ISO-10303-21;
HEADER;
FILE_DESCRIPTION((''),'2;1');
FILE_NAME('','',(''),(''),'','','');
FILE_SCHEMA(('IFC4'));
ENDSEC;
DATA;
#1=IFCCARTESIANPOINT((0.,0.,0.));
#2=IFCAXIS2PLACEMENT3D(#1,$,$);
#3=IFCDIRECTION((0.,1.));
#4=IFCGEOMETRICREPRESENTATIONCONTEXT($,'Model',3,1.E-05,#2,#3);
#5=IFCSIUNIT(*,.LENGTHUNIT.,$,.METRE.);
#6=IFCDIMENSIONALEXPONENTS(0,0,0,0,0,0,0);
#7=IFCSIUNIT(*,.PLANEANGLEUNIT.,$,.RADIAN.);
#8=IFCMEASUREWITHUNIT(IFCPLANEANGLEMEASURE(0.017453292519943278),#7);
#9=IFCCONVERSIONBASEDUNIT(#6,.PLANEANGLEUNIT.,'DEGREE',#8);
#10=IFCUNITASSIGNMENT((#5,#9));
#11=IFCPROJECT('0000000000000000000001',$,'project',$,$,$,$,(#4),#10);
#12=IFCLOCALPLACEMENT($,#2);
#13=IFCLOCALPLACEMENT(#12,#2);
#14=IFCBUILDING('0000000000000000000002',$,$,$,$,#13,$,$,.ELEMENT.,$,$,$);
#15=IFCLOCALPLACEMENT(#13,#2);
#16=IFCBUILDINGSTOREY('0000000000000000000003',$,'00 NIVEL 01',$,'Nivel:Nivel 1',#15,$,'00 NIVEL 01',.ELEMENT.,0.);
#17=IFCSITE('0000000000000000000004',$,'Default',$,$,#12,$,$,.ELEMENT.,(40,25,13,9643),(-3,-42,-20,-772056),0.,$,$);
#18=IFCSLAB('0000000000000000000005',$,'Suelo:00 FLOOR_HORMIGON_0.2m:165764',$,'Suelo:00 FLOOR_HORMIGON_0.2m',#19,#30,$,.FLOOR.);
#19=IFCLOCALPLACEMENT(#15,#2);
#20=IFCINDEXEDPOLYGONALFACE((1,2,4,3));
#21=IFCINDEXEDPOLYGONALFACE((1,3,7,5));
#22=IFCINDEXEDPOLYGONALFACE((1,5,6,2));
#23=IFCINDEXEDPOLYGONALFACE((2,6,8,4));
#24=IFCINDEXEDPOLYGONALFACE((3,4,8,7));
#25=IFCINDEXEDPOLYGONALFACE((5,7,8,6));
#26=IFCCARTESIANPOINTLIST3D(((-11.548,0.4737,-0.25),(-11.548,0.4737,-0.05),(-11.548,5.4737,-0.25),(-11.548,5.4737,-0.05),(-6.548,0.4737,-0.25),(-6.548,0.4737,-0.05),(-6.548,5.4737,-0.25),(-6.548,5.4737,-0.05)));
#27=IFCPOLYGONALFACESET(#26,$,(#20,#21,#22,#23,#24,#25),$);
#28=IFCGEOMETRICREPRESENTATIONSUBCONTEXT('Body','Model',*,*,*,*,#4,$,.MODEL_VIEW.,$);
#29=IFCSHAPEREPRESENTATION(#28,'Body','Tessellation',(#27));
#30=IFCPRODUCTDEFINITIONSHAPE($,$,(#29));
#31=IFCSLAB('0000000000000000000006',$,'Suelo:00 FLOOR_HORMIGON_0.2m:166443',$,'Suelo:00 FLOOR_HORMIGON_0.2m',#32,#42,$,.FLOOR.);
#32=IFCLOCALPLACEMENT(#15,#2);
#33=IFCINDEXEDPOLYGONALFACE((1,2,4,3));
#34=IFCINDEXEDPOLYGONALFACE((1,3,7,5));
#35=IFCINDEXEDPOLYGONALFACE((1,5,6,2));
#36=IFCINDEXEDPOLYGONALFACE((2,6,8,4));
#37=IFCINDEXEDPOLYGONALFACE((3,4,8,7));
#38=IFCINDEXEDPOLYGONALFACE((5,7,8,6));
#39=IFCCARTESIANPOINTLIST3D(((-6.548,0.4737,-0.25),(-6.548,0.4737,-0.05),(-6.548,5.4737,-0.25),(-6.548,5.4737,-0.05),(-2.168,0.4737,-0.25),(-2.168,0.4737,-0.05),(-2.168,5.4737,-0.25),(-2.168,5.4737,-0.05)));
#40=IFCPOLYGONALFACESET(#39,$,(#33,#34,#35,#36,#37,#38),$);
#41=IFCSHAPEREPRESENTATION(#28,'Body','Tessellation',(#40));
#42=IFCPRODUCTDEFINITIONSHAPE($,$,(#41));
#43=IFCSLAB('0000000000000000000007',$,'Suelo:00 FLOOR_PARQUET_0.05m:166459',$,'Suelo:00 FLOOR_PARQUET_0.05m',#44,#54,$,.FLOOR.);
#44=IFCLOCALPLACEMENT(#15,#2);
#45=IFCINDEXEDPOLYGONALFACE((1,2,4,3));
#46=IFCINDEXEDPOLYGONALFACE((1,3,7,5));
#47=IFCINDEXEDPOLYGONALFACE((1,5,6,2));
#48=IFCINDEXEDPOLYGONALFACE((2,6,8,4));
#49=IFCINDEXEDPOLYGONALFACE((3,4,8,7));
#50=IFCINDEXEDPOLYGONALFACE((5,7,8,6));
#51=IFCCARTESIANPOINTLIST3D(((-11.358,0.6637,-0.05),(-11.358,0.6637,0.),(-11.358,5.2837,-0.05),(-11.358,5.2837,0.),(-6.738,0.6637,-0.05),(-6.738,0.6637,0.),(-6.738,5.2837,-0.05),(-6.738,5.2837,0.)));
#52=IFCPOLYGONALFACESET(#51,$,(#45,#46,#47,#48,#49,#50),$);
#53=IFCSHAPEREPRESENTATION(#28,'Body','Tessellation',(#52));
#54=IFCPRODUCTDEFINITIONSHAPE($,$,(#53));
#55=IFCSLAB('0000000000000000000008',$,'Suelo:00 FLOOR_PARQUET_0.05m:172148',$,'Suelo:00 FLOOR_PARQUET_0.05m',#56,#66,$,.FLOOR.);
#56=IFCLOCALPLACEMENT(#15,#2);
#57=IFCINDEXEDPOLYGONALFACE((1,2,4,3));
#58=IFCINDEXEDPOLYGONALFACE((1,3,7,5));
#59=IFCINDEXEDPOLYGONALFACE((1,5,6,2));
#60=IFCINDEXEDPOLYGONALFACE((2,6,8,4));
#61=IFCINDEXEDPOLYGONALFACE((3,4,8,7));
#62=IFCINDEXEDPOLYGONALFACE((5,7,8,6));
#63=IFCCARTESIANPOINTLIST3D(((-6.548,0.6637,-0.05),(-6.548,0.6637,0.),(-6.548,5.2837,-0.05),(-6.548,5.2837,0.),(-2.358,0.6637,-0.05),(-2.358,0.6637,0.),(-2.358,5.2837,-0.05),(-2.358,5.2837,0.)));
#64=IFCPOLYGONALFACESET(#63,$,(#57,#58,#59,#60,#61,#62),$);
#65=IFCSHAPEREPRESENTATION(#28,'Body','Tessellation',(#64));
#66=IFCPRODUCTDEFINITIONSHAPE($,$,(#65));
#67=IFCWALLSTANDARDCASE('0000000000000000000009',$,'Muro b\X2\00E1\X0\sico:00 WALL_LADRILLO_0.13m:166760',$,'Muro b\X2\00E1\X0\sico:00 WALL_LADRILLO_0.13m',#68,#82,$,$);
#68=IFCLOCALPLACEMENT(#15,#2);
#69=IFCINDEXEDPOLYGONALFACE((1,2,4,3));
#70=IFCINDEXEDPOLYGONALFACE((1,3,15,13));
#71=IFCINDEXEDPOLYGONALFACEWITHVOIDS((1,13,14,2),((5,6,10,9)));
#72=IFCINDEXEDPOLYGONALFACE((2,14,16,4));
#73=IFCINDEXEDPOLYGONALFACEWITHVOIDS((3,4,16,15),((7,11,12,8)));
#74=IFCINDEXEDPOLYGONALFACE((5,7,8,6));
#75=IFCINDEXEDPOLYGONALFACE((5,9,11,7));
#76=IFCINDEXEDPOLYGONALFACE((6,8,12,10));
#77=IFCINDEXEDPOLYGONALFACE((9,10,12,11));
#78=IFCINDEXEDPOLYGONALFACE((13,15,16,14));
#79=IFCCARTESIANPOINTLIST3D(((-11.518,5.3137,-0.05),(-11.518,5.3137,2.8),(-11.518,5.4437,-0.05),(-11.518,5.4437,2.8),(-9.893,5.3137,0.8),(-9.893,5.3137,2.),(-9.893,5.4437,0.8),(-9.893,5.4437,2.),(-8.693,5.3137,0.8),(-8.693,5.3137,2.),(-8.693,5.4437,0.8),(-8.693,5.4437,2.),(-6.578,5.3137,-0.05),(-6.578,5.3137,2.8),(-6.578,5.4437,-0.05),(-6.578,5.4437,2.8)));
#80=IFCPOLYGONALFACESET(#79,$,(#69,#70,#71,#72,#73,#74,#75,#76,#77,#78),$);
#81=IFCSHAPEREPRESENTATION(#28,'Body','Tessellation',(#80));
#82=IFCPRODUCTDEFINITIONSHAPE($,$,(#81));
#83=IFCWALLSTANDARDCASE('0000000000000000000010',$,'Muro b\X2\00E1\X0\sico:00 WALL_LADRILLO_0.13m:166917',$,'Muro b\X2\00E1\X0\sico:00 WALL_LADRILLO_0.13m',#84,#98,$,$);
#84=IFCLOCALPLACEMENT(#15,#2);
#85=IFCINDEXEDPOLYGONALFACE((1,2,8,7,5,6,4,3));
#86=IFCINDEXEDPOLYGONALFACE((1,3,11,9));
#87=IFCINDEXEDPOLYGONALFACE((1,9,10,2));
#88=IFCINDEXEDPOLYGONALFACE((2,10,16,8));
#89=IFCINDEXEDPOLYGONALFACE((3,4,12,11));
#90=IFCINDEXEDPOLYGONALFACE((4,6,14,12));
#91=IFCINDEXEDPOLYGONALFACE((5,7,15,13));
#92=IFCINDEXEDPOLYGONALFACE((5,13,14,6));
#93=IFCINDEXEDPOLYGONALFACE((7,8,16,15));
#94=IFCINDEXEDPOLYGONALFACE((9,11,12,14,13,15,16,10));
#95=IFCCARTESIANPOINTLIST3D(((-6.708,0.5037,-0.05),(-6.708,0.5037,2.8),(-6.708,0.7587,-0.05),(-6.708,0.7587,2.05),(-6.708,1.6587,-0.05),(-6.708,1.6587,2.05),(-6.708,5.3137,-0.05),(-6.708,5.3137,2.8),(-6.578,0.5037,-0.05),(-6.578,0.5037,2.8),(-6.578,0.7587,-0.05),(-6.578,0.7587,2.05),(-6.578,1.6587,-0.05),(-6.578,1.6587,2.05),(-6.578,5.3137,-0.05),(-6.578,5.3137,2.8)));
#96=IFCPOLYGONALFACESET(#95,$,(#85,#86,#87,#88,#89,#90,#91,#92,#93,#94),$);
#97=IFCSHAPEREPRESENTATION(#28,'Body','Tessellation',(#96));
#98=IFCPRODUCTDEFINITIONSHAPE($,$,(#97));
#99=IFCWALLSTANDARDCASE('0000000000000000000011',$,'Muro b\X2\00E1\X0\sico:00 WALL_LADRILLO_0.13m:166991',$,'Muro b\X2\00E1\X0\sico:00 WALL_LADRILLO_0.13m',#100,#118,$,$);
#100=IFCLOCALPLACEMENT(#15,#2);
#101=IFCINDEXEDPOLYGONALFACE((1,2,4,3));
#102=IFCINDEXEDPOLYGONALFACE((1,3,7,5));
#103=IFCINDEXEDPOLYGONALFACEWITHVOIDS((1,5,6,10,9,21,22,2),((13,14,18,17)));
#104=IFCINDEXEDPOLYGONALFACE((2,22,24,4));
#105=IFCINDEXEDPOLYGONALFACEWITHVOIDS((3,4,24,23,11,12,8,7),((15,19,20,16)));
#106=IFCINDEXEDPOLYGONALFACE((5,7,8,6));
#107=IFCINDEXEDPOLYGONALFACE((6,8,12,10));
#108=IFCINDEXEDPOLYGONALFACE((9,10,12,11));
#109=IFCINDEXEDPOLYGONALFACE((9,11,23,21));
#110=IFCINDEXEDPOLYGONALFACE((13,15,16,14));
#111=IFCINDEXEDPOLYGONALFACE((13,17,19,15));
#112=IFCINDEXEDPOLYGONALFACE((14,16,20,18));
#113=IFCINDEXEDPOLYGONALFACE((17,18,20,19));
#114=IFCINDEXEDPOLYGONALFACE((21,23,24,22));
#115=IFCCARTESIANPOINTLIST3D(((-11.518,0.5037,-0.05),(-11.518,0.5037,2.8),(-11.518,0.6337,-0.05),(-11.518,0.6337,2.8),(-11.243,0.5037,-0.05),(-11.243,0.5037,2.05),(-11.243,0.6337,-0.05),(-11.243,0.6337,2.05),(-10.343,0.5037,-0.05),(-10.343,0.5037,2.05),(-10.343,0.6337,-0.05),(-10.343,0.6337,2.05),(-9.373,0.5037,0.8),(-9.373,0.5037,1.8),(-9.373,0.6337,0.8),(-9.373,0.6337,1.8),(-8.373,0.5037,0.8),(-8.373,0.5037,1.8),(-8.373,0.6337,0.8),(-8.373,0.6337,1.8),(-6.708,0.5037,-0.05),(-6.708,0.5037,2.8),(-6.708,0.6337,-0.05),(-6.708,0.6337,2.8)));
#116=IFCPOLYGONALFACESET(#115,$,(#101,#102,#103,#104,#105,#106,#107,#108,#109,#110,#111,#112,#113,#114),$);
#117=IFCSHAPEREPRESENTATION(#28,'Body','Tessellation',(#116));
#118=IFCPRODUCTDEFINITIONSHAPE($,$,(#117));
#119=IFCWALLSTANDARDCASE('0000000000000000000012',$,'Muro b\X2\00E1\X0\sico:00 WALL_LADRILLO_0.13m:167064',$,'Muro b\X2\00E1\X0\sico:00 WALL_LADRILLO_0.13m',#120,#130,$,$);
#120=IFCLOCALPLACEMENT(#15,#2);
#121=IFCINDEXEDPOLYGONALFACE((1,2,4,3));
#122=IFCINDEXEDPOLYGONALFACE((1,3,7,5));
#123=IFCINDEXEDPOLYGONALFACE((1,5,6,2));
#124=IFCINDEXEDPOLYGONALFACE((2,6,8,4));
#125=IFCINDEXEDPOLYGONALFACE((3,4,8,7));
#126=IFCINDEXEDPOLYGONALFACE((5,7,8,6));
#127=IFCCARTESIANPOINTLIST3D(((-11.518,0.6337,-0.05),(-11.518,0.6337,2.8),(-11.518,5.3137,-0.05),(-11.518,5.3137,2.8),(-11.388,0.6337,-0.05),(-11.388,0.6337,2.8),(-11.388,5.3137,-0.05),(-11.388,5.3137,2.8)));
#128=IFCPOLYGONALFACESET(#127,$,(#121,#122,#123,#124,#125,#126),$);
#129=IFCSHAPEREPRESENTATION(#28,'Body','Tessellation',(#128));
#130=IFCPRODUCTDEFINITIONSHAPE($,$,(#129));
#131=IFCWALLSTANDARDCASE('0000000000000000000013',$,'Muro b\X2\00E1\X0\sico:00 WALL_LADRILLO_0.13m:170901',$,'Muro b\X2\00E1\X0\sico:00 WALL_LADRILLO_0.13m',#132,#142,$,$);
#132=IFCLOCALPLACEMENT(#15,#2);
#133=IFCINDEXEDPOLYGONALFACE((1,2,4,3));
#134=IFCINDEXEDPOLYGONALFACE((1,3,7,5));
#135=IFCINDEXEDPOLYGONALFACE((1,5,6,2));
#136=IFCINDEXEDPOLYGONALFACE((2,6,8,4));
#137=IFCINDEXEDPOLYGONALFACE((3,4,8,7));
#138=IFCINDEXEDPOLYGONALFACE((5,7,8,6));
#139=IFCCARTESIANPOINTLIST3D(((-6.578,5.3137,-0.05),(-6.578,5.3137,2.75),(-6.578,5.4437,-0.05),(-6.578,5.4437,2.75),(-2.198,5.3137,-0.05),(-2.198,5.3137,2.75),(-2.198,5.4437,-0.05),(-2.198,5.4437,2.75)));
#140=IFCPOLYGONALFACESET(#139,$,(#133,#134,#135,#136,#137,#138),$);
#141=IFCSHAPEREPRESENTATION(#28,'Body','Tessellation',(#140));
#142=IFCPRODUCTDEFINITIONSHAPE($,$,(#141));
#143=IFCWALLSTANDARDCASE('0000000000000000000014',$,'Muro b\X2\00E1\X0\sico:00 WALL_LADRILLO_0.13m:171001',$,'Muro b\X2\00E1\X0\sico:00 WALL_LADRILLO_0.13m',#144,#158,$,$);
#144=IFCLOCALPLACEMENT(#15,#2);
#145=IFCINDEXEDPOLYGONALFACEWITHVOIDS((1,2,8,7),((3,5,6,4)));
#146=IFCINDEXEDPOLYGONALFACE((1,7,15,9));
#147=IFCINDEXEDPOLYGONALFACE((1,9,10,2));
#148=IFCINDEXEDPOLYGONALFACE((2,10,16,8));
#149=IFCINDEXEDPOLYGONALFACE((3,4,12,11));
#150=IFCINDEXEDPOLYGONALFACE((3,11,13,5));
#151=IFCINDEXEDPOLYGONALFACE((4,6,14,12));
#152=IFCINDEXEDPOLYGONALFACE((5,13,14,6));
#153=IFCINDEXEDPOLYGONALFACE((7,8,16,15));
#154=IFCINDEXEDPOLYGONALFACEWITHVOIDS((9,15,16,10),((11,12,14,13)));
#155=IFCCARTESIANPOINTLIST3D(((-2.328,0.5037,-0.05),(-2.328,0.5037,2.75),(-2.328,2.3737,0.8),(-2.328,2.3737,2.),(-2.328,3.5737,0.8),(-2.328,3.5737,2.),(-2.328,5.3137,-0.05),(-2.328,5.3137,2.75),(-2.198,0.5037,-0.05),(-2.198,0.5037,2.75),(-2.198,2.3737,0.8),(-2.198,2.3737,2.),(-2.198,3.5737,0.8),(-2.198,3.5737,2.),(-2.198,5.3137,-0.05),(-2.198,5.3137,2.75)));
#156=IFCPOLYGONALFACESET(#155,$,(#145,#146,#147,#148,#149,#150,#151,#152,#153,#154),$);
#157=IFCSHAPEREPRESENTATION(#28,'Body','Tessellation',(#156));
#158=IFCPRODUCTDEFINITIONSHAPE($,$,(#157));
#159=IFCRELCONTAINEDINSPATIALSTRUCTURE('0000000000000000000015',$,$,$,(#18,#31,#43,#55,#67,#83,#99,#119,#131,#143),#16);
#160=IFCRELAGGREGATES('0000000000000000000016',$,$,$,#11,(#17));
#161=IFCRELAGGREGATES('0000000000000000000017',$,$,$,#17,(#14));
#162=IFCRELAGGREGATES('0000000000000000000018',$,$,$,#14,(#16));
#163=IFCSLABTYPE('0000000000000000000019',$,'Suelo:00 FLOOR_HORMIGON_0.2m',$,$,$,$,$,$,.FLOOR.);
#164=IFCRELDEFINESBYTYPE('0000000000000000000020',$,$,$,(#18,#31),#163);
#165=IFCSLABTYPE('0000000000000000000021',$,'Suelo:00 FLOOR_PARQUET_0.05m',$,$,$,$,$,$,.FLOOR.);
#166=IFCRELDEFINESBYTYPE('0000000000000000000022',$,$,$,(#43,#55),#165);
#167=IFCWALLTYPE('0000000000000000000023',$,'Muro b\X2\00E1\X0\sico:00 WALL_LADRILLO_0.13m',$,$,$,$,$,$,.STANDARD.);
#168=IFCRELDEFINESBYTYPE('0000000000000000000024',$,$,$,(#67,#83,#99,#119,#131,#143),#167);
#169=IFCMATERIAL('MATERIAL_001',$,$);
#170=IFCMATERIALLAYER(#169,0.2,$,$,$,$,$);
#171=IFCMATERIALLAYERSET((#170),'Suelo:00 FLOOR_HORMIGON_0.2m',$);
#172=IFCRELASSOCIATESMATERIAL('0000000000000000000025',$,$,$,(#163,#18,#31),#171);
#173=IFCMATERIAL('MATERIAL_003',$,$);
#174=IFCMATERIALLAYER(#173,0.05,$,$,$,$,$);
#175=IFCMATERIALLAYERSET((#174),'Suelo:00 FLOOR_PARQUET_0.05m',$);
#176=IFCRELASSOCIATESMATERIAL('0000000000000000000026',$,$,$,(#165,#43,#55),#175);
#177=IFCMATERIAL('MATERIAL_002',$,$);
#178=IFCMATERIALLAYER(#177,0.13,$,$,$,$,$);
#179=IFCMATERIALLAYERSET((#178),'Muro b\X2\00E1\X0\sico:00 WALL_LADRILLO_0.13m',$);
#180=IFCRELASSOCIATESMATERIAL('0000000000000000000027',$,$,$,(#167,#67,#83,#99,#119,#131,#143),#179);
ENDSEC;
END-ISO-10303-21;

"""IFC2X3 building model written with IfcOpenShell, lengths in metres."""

from ifc_helpers import new_model, entity, si_unit, converted_unit, direction, frame, frame_2d, origin, place, context, subcontext, project, spatial, rectangle, extrude, material, layer, layer_set, layer_usage, type_object, element, save


model = new_model("IFC2X3")

# Units and contexts
model_context = context("Model", 3, precision=1e-05, world=origin(), true_north=direction((0.0, 1.0)))
body_context = subcontext(model_context, "Body", "Model", "MODEL_VIEW")
ifc_project = project(units=[si_unit("LENGTHUNIT", "METRE"), converted_unit("PLANEANGLEUNIT", "DEGREE", entity("IfcPlaneAngleMeasure", 0.017453292519943278), si_unit("PLANEANGLEUNIT", "RADIAN"), dimensions=[0, 0, 0, 0, 0, 0, 0])], contexts=[model_context])

# Site, building, storey
site_placement = place(None, origin())
site = spatial("IfcSite", under=ifc_project, at=site_placement, Name="Default", CompositionType="ELEMENT", RefLatitude=(40, 25, 13, 9643), RefLongitude=(-3, -42, -20, -772056), RefElevation=0.0)
building_placement = place(site_placement, origin())
building = spatial("IfcBuilding", under=site, at=building_placement, CompositionType="ELEMENT")
storey_placement = place(building_placement, origin())
storey = spatial("IfcBuildingStorey", under=building, at=storey_placement, Name="00 NIVEL 01", ObjectType="Nivel:Nivel 1", LongName="00 NIVEL 01", CompositionType="ELEMENT", Elevation=0.0)

# Slabs
ifc_material_1 = material(Name="MATERIAL_001")
ifc_layer_1 = layer(ifc_material_1, 0.2)
ifc_layer_set_1 = layer_set([ifc_layer_1], Name="Suelo:00 FLOOR_HORMIGON_0.2m")
ifc_layer_usage_1 = layer_usage(ifc_layer_set_1, "AXIS3", "POSITIVE", 0.0)
slab_type_1 = type_object("IfcSlabType", Name="Suelo:00 FLOOR_HORMIGON_0.2m", PredefinedType="FLOOR", material=ifc_layer_set_1)
slab_1_placement = place(storey_placement, origin())
element("IfcSlab", 1, at=slab_1_placement, inside=storey, type_object=slab_type_1, material=ifc_layer_usage_1, Name="Suelo:00 FLOOR_HORMIGON_0.2m:165764", ObjectType="Suelo:00 FLOOR_HORMIGON_0.2m", PredefinedType="FLOOR", context=body_context, shape_type="SweptSolid", body=[
    extrude(rectangle(XDim=5.0, YDim=5.0, at=frame_2d((0.0, 0.0), x_axis=(1.0, 0.0))), frame((-9.048, 2.9737, -0.05), z_axis=(0.0, 0.0, -1.0), x_axis=(0.0, 1.0, 0.0)), (0.0, 0.0, 1.0), 0.2),
])
ifc_layer_usage_2 = layer_usage(ifc_layer_set_1, "AXIS3", "POSITIVE", 0.0)
slab_2_placement = place(storey_placement, origin())
element("IfcSlab", 2, at=slab_2_placement, inside=storey, type_object=slab_type_1, material=ifc_layer_usage_2, Name="Suelo:00 FLOOR_HORMIGON_0.2m:166443", ObjectType="Suelo:00 FLOOR_HORMIGON_0.2m", PredefinedType="FLOOR", context=body_context, shape_type="SweptSolid", body=[
    extrude(rectangle(XDim=5.0, YDim=4.38, at=frame_2d((0.0, 0.0), x_axis=(1.0, 0.0))), frame((-4.358, 2.9737, -0.05), z_axis=(0.0, 0.0, -1.0), x_axis=(0.0, 1.0, 0.0)), (0.0, 0.0, 1.0), 0.2),
])
ifc_material_2 = material(Name="MATERIAL_003")
ifc_layer_2 = layer(ifc_material_2, 0.05)
ifc_layer_set_2 = layer_set([ifc_layer_2], Name="Suelo:00 FLOOR_PARQUET_0.05m")
ifc_layer_usage_3 = layer_usage(ifc_layer_set_2, "AXIS3", "POSITIVE", 0.0)
slab_type_2 = type_object("IfcSlabType", Name="Suelo:00 FLOOR_PARQUET_0.05m", PredefinedType="FLOOR", material=ifc_layer_set_2)
slab_3_placement = place(storey_placement, origin())
element("IfcSlab", 3, at=slab_3_placement, inside=storey, type_object=slab_type_2, material=ifc_layer_usage_3, Name="Suelo:00 FLOOR_PARQUET_0.05m:166459", ObjectType="Suelo:00 FLOOR_PARQUET_0.05m", PredefinedType="FLOOR", context=body_context, shape_type="SweptSolid", body=[
    extrude(rectangle(XDim=4.62, YDim=4.62, at=frame_2d((0.0, 0.0), x_axis=(1.0, 0.0))), frame((-9.048, 2.9737, 0.0), z_axis=(0.0, 0.0, -1.0), x_axis=(0.0, 1.0, 0.0)), (0.0, 0.0, 1.0), 0.05),
])
ifc_layer_usage_4 = layer_usage(ifc_layer_set_2, "AXIS3", "POSITIVE", 0.0)
slab_4_placement = place(storey_placement, origin())
element("IfcSlab", 4, at=slab_4_placement, inside=storey, type_object=slab_type_2, material=ifc_layer_usage_4, Name="Suelo:00 FLOOR_PARQUET_0.05m:172148", ObjectType="Suelo:00 FLOOR_PARQUET_0.05m", PredefinedType="FLOOR", context=body_context, shape_type="SweptSolid", body=[
    extrude(rectangle(XDim=4.62, YDim=4.19, at=frame_2d((0.0, 0.0), x_axis=(1.0, 0.0))), frame((-4.453, 2.9737, 0.0), z_axis=(0.0, 0.0, -1.0), x_axis=(0.0, 1.0, 0.0)), (0.0, 0.0, 1.0), 0.05),
])

# Walls, openings
ifc_material_3 = material(Name="MATERIAL_002")
ifc_layer_3 = layer(ifc_material_3, 0.13)
ifc_layer_set_3 = layer_set([ifc_layer_3], Name="Muro básico:00 WALL_LADRILLO_0.13m")
ifc_layer_usage_5 = layer_usage(ifc_layer_set_3, "AXIS2", "NEGATIVE", 0.065)
wall_type_1 = type_object("IfcWallType", Name="Muro básico:00 WALL_LADRILLO_0.13m", PredefinedType="STANDARD", material=ifc_layer_set_3)
wall_1_placement = place(storey_placement, frame((-11.518, 5.3787, -0.05)))
wall_1 = element("IfcWallStandardCase", 5, at=wall_1_placement, inside=storey, type_object=wall_type_1, material=ifc_layer_usage_5, Name="Muro básico:00 WALL_LADRILLO_0.13m:166760", ObjectType="Muro básico:00 WALL_LADRILLO_0.13m", context=body_context, shape_type="SweptSolid", body=[
    extrude(rectangle(XDim=4.94, YDim=0.13, at=frame_2d((2.47, 0.0), x_axis=(-1.0, 0.0))), origin(), (0.0, 0.0, 1.0), 2.85),
])
opening_1_placement = place(wall_1_placement, frame((1.625, -0.065, 0.85)))
element("IfcOpeningElement", 6, at=opening_1_placement, cuts=wall_1, ObjectType="Opening", context=body_context, shape_type="SweptSolid", body=[
    extrude(rectangle(XDim=1.2, YDim=1.2, at=frame_2d((0.6, 0.6), x_axis=(1.0, 0.0))), frame((0.0, 0.0, 0.0), z_axis=(0.0, 1.0, 0.0), x_axis=(0.0, 0.0, 1.0)), (0.0, 0.0, 1.0), 0.13),
])
ifc_layer_usage_6 = layer_usage(ifc_layer_set_3, "AXIS2", "NEGATIVE", 0.065)
wall_2_placement = place(storey_placement, frame((-6.643, 5.3137, -0.05), z_axis=(0.0, 0.0, 1.0), x_axis=(0.0, -1.0, 0.0)))
wall_2 = element("IfcWallStandardCase", 7, at=wall_2_placement, inside=storey, type_object=wall_type_1, material=ifc_layer_usage_6, Name="Muro básico:00 WALL_LADRILLO_0.13m:166917", ObjectType="Muro básico:00 WALL_LADRILLO_0.13m", context=body_context, shape_type="SweptSolid", body=[
    extrude(rectangle(XDim=4.81, YDim=0.13, at=frame_2d((2.405, 0.0), x_axis=(-1.0, 0.0))), origin(), (0.0, 0.0, 1.0), 2.85),
])
opening_2_placement = place(wall_2_placement, frame((3.655, -0.065, 0.0)))
element("IfcOpeningElement", 8, at=opening_2_placement, cuts=wall_2, ObjectType="Opening", context=body_context, shape_type="SweptSolid", body=[
    extrude(rectangle(XDim=2.1, YDim=0.9, at=frame_2d((1.05, 0.45), x_axis=(1.0, 0.0))), frame((0.0, 0.0, 0.0), z_axis=(0.0, 1.0, 0.0), x_axis=(0.0, 0.0, 1.0)), (0.0, 0.0, 1.0), 0.13),
])

# Wall, openings
ifc_layer_usage_7 = layer_usage(ifc_layer_set_3, "AXIS2", "NEGATIVE", 0.065)
wall_3_placement = place(storey_placement, frame((-6.708, 0.5687, -0.05), z_axis=(0.0, 0.0, 1.0), x_axis=(-1.0, 0.0, 0.0)))
wall_3 = element("IfcWallStandardCase", 9, at=wall_3_placement, inside=storey, type_object=wall_type_1, material=ifc_layer_usage_7, Name="Muro básico:00 WALL_LADRILLO_0.13m:166991", ObjectType="Muro básico:00 WALL_LADRILLO_0.13m", context=body_context, shape_type="SweptSolid", body=[
    extrude(rectangle(XDim=4.81, YDim=0.13, at=frame_2d((2.405, 0.0), x_axis=(1.0, 0.0))), origin(), (0.0, 0.0, 1.0), 2.85),
])
opening_3_placement = place(wall_3_placement, frame((4.535, 0.065, 0.0)))
element("IfcOpeningElement", 10, at=opening_3_placement, cuts=wall_3, ObjectType="Opening", context=body_context, shape_type="SweptSolid", body=[
    extrude(rectangle(XDim=2.1, YDim=0.9, at=frame_2d((1.05, 0.45), x_axis=(1.0, 0.0))), frame((0.0, 0.0, 0.0), z_axis=(0.0, -1.0, 0.0), x_axis=(0.0, 0.0, 1.0)), (0.0, 0.0, 1.0), 0.13),
])
opening_4_placement = place(wall_3_placement, frame((2.665, 0.065, 0.85)))
element("IfcOpeningElement", 11, at=opening_4_placement, cuts=wall_3, ObjectType="Opening", context=body_context, shape_type="SweptSolid", body=[
    extrude(rectangle(XDim=1.0, YDim=1.0, at=frame_2d((0.5, 0.5), x_axis=(1.0, 0.0))), frame((0.0, 0.0, 0.0), z_axis=(0.0, -1.0, 0.0), x_axis=(0.0, 0.0, 1.0)), (0.0, 0.0, 1.0), 0.13),
])

# Walls
ifc_layer_usage_8 = layer_usage(ifc_layer_set_3, "AXIS2", "NEGATIVE", 0.065)
wall_4_placement = place(storey_placement, frame((-11.453, 0.6337, -0.05), z_axis=(0.0, 0.0, 1.0), x_axis=(0.0, 1.0, 0.0)))
element("IfcWallStandardCase", 12, at=wall_4_placement, inside=storey, type_object=wall_type_1, material=ifc_layer_usage_8, Name="Muro básico:00 WALL_LADRILLO_0.13m:167064", ObjectType="Muro básico:00 WALL_LADRILLO_0.13m", context=body_context, shape_type="SweptSolid", body=[
    extrude(rectangle(XDim=4.68, YDim=0.13, at=frame_2d((2.34, 0.0), x_axis=(-1.0, 0.0))), origin(), (0.0, 0.0, 1.0), 2.85),
])
ifc_layer_usage_9 = layer_usage(ifc_layer_set_3, "AXIS2", "NEGATIVE", 0.065)
wall_5_placement = place(storey_placement, frame((-6.578, 5.3787, -0.05)))
element("IfcWallStandardCase", 13, at=wall_5_placement, inside=storey, type_object=wall_type_1, material=ifc_layer_usage_9, Name="Muro básico:00 WALL_LADRILLO_0.13m:170901", ObjectType="Muro básico:00 WALL_LADRILLO_0.13m", context=body_context, shape_type="SweptSolid", body=[
    extrude(rectangle(XDim=4.38, YDim=0.13, at=frame_2d((2.19, 0.0), x_axis=(-1.0, 0.0))), origin(), (0.0, 0.0, 1.0), 2.8),
])

# Wall, opening
ifc_layer_usage_10 = layer_usage(ifc_layer_set_3, "AXIS2", "NEGATIVE", 0.065)
wall_6_placement = place(storey_placement, frame((-2.263, 5.3137, -0.05), z_axis=(0.0, 0.0, 1.0), x_axis=(0.0, -1.0, 0.0)))
wall_6 = element("IfcWallStandardCase", 14, at=wall_6_placement, inside=storey, type_object=wall_type_1, material=ifc_layer_usage_10, Name="Muro básico:00 WALL_LADRILLO_0.13m:171001", ObjectType="Muro básico:00 WALL_LADRILLO_0.13m", context=body_context, shape_type="SweptSolid", body=[
    extrude(rectangle(XDim=4.81, YDim=0.13, at=frame_2d((2.405, 0.0), x_axis=(-1.0, 0.0))), origin(), (0.0, 0.0, 1.0), 2.8),
])
opening_5_placement = place(wall_6_placement, frame((2.94, 0.065, 0.85)))
element("IfcOpeningElement", 15, at=opening_5_placement, cuts=wall_6, ObjectType="Opening", context=body_context, shape_type="SweptSolid", body=[
    extrude(rectangle(XDim=1.2, YDim=1.2, at=frame_2d((0.6, 0.6), x_axis=(1.0, 0.0))), frame((0.0, 0.0, 0.0), z_axis=(0.0, -1.0, 0.0), x_axis=(0.0, 0.0, 1.0)), (0.0, 0.0, 1.0), 0.13),
])

save(model, "model.ifc")
